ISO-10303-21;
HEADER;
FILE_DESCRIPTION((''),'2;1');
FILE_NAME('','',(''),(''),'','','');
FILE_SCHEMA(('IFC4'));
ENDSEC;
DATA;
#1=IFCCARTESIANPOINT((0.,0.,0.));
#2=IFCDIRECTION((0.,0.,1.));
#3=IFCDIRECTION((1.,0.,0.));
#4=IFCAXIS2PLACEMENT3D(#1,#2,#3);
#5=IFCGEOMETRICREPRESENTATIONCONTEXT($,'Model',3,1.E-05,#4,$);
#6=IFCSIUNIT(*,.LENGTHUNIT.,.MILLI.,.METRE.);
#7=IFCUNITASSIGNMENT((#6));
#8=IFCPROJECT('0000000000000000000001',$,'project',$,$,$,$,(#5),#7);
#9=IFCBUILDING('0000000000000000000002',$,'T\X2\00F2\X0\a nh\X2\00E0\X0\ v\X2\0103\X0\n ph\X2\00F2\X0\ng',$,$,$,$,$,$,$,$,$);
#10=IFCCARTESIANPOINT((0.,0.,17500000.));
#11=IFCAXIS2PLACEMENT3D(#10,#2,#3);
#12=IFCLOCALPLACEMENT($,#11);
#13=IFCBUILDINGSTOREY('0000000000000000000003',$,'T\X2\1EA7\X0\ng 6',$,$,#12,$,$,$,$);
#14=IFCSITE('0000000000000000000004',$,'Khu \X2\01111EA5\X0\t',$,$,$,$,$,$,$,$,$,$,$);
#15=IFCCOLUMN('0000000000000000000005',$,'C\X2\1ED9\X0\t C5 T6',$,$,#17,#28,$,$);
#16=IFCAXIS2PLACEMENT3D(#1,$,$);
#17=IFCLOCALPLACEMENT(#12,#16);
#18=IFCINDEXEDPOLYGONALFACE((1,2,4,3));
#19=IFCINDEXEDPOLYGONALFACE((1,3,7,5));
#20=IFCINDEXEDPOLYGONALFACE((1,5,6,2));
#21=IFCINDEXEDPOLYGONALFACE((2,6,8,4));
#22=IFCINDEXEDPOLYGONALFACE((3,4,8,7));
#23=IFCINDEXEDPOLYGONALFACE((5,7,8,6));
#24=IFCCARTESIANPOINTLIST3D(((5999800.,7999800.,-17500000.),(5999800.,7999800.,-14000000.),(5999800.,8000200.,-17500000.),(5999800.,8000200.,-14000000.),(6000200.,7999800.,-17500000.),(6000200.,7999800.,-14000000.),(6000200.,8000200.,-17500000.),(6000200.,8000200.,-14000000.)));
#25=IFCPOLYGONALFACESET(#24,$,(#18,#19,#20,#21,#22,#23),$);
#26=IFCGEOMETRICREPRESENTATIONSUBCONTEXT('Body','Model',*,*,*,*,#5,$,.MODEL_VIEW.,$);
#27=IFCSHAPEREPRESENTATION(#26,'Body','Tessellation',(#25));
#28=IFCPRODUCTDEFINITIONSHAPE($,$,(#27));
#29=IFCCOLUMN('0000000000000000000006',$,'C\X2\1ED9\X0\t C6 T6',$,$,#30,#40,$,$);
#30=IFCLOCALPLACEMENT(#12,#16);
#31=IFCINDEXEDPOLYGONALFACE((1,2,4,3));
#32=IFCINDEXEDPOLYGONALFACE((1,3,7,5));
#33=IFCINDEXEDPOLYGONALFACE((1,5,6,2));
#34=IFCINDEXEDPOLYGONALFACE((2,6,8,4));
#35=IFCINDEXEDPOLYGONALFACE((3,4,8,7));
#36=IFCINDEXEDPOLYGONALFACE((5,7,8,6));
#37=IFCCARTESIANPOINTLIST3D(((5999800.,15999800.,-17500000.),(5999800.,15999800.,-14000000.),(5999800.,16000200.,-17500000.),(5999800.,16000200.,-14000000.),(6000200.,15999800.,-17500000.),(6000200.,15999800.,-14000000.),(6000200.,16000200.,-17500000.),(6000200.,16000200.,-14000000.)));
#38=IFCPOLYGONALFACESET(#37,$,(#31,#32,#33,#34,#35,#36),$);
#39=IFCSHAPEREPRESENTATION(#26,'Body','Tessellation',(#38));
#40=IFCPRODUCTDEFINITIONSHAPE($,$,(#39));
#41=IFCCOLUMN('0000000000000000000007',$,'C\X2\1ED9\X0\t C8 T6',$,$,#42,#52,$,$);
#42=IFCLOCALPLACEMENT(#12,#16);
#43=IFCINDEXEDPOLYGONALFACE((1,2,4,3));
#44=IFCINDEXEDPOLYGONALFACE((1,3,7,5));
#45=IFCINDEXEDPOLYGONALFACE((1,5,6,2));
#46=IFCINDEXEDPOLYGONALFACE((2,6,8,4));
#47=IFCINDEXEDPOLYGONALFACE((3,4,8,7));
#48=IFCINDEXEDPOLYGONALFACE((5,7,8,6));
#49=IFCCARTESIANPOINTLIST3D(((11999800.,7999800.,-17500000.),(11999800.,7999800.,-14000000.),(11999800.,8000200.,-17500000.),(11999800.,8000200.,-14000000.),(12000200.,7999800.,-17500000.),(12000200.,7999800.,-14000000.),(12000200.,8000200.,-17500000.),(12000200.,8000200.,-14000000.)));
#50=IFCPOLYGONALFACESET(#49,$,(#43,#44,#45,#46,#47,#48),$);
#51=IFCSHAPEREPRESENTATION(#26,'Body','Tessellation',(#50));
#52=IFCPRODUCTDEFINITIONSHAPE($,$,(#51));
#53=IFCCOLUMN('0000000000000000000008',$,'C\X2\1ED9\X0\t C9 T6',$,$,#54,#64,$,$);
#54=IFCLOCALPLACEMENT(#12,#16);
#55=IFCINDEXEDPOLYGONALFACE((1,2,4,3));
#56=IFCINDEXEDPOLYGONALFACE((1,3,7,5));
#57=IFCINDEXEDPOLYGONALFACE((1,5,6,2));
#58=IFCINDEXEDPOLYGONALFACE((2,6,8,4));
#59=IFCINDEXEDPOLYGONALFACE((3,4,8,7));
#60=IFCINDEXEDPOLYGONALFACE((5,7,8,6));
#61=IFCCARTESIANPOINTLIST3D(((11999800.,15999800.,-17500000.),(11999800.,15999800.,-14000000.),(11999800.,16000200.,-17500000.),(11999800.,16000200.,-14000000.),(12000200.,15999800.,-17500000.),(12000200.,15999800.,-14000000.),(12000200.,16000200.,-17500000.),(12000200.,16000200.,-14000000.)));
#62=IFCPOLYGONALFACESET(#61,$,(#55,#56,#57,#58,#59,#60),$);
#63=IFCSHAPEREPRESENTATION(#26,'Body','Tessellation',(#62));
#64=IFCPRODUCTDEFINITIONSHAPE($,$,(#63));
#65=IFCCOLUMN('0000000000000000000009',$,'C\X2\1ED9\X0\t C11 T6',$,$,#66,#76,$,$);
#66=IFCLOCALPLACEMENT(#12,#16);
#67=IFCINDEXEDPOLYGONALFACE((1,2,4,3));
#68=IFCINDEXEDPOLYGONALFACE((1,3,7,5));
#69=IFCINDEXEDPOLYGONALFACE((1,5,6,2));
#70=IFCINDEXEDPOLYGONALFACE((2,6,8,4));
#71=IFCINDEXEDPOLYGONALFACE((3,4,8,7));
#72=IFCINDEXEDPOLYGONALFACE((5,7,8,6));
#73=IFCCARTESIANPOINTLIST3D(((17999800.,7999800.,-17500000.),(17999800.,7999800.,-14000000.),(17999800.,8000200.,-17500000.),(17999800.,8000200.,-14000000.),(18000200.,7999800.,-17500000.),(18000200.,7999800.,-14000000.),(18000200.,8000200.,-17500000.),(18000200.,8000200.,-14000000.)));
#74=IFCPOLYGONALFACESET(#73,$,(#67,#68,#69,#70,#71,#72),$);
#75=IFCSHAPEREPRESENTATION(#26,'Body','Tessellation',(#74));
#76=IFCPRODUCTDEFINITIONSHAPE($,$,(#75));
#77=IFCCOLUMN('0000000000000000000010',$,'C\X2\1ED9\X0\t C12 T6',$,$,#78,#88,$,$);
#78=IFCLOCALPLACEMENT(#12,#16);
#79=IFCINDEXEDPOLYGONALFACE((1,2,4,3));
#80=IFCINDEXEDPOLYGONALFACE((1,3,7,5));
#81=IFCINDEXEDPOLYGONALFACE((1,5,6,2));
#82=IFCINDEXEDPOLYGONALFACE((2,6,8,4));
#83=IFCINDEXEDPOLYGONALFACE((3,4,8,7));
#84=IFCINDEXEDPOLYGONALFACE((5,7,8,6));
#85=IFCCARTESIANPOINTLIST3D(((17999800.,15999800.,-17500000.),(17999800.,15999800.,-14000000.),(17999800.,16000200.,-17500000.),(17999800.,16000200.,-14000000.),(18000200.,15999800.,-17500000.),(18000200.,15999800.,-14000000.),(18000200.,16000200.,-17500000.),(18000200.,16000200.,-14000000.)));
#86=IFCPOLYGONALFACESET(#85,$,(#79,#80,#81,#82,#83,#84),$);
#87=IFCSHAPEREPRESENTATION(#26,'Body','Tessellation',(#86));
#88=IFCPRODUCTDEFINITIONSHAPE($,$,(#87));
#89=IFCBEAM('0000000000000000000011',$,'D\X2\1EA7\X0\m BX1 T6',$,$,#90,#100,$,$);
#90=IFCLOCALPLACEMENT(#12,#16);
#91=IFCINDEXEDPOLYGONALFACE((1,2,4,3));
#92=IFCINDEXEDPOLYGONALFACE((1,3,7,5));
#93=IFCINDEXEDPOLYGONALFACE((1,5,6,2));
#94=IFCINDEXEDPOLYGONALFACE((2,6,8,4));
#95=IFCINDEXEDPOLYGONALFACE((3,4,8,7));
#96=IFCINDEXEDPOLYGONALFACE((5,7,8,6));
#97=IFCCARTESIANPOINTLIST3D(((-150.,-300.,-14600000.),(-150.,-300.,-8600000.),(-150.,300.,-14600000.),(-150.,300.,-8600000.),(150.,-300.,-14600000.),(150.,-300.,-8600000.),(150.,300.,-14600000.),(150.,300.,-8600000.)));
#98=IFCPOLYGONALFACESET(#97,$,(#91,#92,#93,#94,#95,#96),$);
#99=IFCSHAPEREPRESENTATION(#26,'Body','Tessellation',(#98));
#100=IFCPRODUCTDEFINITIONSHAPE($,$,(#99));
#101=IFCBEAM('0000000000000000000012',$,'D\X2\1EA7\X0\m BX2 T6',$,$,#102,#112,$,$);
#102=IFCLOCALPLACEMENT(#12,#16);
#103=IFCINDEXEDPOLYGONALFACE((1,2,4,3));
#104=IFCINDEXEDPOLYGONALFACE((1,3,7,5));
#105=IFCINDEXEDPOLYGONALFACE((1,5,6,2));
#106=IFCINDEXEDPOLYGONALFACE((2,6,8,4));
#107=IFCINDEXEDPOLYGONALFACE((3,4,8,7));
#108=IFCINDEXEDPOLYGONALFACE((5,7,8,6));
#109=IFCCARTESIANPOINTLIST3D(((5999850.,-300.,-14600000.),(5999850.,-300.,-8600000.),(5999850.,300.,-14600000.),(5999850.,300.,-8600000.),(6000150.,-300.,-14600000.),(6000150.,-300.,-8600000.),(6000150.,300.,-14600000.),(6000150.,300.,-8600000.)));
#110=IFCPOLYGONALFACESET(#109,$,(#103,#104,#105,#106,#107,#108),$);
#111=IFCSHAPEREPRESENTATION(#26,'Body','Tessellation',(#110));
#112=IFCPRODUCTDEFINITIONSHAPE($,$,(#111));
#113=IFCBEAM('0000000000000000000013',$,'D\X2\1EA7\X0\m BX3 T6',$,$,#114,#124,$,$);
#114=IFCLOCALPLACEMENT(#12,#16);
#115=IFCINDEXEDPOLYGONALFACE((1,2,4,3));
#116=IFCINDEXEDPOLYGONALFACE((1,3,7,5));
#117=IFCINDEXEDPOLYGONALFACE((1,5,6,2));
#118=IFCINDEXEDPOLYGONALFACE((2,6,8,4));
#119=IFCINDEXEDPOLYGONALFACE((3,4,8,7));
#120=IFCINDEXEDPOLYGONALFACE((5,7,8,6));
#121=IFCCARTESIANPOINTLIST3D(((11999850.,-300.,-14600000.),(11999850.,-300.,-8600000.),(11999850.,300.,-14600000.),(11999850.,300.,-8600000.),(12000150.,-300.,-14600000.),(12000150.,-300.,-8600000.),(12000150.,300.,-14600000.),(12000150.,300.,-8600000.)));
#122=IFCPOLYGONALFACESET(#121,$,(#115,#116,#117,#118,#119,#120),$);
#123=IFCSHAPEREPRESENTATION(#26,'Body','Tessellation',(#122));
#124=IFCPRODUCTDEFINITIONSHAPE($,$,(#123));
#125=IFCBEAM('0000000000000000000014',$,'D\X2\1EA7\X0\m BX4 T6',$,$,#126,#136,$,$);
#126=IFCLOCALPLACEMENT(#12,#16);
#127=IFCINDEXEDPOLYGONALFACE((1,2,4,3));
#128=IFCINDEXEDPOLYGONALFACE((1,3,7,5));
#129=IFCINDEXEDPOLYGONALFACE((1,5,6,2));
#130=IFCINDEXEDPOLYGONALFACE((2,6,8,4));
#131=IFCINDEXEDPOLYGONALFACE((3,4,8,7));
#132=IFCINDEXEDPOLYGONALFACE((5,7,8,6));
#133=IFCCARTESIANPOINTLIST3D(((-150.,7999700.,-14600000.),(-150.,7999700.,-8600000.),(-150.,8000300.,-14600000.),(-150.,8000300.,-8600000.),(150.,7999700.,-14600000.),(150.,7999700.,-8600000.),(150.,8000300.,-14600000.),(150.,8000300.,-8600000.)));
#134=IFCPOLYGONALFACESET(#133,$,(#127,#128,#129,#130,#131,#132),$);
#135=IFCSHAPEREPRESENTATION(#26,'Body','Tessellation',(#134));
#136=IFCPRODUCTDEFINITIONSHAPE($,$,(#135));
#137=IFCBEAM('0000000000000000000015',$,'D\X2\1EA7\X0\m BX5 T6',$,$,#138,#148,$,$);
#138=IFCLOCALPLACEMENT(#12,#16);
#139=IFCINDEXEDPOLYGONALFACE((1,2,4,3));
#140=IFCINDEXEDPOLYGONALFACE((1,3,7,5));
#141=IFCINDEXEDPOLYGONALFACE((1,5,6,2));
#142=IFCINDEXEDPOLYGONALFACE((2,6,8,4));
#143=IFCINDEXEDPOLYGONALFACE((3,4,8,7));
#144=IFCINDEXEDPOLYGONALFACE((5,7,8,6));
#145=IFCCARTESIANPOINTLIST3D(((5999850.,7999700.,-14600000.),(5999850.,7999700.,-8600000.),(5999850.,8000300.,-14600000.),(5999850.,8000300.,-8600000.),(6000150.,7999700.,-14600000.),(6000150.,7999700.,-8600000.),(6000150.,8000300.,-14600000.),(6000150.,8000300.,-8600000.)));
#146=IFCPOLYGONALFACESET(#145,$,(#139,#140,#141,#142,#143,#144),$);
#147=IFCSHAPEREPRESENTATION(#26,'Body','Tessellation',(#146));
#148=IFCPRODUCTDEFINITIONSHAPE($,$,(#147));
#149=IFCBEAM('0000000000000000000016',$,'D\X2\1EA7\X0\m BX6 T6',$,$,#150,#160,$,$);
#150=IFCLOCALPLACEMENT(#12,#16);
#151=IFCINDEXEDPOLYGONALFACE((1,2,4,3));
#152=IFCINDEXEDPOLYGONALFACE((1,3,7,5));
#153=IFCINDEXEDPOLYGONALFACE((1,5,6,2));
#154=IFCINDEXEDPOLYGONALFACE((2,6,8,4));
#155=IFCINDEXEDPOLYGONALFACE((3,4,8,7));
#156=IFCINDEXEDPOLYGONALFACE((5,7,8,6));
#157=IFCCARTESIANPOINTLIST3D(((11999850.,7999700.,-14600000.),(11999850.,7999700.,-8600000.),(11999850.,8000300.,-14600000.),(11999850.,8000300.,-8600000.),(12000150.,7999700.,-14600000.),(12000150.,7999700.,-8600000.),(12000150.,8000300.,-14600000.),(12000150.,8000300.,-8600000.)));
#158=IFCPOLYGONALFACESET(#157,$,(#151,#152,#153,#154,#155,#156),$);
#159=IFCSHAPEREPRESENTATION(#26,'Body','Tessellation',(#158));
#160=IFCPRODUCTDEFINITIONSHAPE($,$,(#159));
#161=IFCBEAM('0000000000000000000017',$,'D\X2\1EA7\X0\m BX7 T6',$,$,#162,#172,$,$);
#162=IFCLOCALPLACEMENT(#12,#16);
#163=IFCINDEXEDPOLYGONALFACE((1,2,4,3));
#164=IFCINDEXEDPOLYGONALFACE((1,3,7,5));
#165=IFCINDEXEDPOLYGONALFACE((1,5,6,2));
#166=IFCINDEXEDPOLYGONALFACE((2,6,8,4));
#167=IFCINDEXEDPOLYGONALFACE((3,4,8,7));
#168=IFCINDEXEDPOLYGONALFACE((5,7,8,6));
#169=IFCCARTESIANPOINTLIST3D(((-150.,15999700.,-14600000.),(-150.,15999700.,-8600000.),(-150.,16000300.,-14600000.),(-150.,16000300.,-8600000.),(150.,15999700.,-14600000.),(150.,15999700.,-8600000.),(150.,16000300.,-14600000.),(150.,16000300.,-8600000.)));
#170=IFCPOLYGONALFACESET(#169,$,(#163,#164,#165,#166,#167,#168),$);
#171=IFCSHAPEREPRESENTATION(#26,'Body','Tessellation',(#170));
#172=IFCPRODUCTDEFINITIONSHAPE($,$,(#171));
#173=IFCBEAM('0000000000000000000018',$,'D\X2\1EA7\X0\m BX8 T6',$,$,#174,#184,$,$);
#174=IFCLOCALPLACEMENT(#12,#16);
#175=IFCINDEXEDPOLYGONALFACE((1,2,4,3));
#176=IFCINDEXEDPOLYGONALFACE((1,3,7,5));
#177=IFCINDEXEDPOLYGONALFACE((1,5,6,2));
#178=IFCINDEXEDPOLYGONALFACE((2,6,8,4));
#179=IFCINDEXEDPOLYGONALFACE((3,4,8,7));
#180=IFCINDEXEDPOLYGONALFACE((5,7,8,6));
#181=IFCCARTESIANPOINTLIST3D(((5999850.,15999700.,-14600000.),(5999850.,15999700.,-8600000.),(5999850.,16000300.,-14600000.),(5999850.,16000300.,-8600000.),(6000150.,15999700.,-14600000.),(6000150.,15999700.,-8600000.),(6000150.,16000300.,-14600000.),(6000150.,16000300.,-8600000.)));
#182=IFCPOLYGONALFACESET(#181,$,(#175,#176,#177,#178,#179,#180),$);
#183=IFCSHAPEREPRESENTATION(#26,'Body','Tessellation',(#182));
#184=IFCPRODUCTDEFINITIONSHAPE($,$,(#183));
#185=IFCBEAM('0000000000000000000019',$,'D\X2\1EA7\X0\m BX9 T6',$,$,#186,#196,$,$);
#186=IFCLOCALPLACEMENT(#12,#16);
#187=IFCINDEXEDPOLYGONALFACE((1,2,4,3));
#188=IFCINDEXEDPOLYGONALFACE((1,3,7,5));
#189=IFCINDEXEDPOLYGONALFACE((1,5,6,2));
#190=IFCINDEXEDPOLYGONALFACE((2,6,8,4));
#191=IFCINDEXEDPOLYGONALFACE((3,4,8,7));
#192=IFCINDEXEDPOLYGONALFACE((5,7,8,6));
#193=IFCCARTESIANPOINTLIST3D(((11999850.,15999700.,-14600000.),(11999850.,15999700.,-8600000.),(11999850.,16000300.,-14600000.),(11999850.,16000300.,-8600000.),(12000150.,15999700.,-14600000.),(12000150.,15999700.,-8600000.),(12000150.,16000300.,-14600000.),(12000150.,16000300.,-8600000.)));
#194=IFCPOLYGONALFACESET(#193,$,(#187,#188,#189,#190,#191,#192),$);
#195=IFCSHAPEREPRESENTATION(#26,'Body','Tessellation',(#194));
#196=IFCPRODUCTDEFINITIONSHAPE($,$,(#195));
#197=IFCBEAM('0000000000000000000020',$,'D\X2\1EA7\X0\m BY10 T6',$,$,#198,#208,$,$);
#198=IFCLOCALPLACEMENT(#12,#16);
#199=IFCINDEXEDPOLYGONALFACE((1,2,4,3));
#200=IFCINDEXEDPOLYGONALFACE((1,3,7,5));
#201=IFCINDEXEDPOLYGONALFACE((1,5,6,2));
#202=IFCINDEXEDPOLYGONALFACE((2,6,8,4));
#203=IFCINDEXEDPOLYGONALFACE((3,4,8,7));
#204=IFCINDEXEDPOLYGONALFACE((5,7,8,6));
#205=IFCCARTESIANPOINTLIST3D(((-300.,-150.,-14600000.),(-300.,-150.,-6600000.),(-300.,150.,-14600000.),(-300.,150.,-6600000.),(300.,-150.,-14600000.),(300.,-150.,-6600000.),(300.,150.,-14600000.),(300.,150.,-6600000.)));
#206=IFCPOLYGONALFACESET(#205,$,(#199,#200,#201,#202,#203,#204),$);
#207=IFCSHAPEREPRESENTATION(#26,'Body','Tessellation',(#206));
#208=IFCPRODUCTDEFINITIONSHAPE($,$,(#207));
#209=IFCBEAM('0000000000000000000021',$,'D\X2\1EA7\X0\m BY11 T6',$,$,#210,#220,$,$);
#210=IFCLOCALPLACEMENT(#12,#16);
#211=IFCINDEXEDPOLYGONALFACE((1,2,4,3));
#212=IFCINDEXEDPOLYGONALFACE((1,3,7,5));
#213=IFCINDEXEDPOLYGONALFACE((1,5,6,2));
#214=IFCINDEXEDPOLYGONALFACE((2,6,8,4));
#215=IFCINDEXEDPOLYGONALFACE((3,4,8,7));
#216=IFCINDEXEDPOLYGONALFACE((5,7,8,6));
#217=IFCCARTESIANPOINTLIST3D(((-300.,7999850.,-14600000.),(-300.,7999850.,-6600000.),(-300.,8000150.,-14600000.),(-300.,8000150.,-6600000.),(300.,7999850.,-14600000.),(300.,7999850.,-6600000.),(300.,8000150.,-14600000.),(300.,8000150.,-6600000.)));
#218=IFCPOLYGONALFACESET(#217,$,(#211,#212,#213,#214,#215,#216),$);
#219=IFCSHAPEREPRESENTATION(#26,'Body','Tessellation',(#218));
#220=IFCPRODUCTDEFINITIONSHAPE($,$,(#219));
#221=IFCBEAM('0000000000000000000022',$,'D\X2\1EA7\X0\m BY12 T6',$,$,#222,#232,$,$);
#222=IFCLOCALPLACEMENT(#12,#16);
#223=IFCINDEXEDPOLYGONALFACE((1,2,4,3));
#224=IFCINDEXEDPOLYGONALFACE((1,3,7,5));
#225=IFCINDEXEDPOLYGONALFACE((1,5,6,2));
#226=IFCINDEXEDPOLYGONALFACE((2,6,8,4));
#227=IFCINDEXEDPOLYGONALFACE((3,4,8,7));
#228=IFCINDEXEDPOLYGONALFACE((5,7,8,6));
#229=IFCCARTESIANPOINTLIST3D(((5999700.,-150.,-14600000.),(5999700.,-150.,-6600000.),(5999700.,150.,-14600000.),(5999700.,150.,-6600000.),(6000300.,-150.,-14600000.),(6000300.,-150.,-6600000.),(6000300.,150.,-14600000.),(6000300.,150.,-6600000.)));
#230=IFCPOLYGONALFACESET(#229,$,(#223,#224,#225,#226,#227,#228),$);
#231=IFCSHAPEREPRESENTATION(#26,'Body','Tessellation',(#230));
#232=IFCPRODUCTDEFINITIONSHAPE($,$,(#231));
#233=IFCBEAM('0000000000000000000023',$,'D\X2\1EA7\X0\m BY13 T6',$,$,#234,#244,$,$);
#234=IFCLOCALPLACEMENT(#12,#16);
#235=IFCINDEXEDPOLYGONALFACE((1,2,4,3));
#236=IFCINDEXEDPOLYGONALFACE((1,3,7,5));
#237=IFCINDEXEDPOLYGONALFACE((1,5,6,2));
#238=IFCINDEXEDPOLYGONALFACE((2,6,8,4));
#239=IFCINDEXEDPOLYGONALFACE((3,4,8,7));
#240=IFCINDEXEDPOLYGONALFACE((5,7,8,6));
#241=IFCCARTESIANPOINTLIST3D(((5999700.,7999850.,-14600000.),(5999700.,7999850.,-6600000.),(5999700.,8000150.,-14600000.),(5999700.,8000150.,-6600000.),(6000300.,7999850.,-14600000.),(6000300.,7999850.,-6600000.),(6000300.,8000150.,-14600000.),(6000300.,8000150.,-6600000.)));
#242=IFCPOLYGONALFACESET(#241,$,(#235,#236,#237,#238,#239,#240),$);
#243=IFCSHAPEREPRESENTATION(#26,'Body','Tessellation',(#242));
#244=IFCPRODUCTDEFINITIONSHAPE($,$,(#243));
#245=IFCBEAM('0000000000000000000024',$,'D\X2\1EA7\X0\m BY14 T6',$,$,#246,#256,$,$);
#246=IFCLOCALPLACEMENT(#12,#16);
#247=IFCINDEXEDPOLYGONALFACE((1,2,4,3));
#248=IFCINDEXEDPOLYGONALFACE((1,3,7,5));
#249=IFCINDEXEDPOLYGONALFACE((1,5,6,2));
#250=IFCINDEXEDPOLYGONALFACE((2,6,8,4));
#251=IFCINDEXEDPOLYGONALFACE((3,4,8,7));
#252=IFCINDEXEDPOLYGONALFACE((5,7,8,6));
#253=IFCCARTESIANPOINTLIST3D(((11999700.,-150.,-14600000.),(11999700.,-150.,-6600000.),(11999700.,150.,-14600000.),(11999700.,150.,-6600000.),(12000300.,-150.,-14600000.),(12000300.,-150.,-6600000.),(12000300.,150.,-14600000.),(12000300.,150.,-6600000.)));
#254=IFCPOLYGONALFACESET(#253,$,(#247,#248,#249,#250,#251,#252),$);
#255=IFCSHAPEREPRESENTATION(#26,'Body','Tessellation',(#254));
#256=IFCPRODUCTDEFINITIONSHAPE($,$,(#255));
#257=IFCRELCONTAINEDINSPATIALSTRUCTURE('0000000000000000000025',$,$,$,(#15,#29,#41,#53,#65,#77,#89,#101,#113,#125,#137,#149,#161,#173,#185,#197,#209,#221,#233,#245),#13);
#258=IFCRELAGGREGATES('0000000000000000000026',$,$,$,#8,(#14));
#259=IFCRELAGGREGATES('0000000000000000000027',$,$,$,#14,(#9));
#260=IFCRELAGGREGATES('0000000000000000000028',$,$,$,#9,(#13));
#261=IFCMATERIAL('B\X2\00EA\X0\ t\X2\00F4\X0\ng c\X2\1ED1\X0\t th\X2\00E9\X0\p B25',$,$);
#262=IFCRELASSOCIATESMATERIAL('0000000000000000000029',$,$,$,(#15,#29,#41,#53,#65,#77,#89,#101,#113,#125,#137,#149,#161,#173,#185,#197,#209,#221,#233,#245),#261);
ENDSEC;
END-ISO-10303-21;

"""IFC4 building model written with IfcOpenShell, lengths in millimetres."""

from ifc_helpers import new_model, entity, si_unit, frame, origin_with_axes, place, context, subcontext, project, spatial, extrude, material, element, save


model = new_model("IFC4")

# Units and contexts
model_context = context("Model", 3, precision=1e-05, world=origin_with_axes())
body_context = subcontext(model_context, "Body", "Model", "MODEL_VIEW")
ifc_project = project(units=[si_unit("LENGTHUNIT", "METRE", prefix="MILLI")], contexts=[model_context])

# Site, building, storey
site = spatial("IfcSite", under=ifc_project, Name="Khu đất")
building = spatial("IfcBuilding", under=site, Name="Tòa nhà văn phòng")
storey_placement = place(None, frame((0.0, 0.0, 17500000.0), z_axis=(0.0, 0.0, 1.0), x_axis=(1.0, 0.0, 0.0)))
storey = spatial("IfcBuildingStorey", under=building, at=storey_placement, Name="Tầng 6")

# Columns
ifc_material_1 = material(Name="Bê tông cốt thép B25")
for number, where, z_axis, x_axis, name in (
    (1, (6000000.0, 8000000.0, -17500000.0), (0.0, 0.0, 1.0), (1.0, 0.0, 0.0), "Cột C5 T6"),
    (2, (6000000.0, 16000000.0, -17500000.0), (0.0, 0.0, 1.0), (1.0, 0.0, 0.0), "Cột C6 T6"),
    (3, (12000000.0, 8000000.0, -17500000.0), (0.0, 0.0, 1.0), (1.0, 0.0, 0.0), "Cột C8 T6"),
    (4, (12000000.0, 16000000.0, -17500000.0), (0.0, 0.0, 1.0), (1.0, 0.0, 0.0), "Cột C9 T6"),
    (5, (18000000.0, 8000000.0, -17500000.0), (0.0, 0.0, 1.0), (1.0, 0.0, 0.0), "Cột C11 T6"),
    (6, (18000000.0, 16000000.0, -17500000.0), (0.0, 0.0, 1.0), (1.0, 0.0, 0.0), "Cột C12 T6"),
):
    element("IfcColumn", number, at=place(storey_placement, frame(where, z_axis=z_axis, x_axis=x_axis)), inside=storey, material=ifc_material_1, Name=name, context=body_context, shape_type="SweptSolid", body=[
        extrude(entity("IfcRectangleProfileDef", None, None, None, 400.0, 400.0), origin_with_axes(), (0.0, 0.0, 1.0), 3500000.0),
    ])

# Beams
for number, where, z_axis, x_axis, name in (
    (7, (0.0, 0.0, -14600000.0), (0.0, 0.0, 1.0), (1.0, 0.0, 0.0), "Dầm BX1 T6"),
    (8, (6000000.0, 0.0, -14600000.0), (0.0, 0.0, 1.0), (1.0, 0.0, 0.0), "Dầm BX2 T6"),
    (9, (12000000.0, 0.0, -14600000.0), (0.0, 0.0, 1.0), (1.0, 0.0, 0.0), "Dầm BX3 T6"),
    (10, (0.0, 8000000.0, -14600000.0), (0.0, 0.0, 1.0), (1.0, 0.0, 0.0), "Dầm BX4 T6"),
    (11, (6000000.0, 8000000.0, -14600000.0), (0.0, 0.0, 1.0), (1.0, 0.0, 0.0), "Dầm BX5 T6"),
    (12, (12000000.0, 8000000.0, -14600000.0), (0.0, 0.0, 1.0), (1.0, 0.0, 0.0), "Dầm BX6 T6"),
    (13, (0.0, 16000000.0, -14600000.0), (0.0, 0.0, 1.0), (1.0, 0.0, 0.0), "Dầm BX7 T6"),
    (14, (6000000.0, 16000000.0, -14600000.0), (0.0, 0.0, 1.0), (1.0, 0.0, 0.0), "Dầm BX8 T6"),
    (15, (12000000.0, 16000000.0, -14600000.0), (0.0, 0.0, 1.0), (1.0, 0.0, 0.0), "Dầm BX9 T6"),
):
    element("IfcBeam", number, at=place(storey_placement, frame(where, z_axis=z_axis, x_axis=x_axis)), inside=storey, material=ifc_material_1, Name=name, context=body_context, shape_type="SweptSolid", body=[
        extrude(entity("IfcRectangleProfileDef", None, None, None, 300.0, 600.0), origin_with_axes(), (0.0, 0.0, 1.0), 6000000.0),
    ])
for number, where, z_axis, x_axis, name in (
    (16, (0.0, 0.0, -14600000.0), (0.0, 0.0, 1.0), (0.0, 1.0, 0.0), "Dầm BY10 T6"),
    (17, (0.0, 8000000.0, -14600000.0), (0.0, 0.0, 1.0), (0.0, 1.0, 0.0), "Dầm BY11 T6"),
    (18, (6000000.0, 0.0, -14600000.0), (0.0, 0.0, 1.0), (0.0, 1.0, 0.0), "Dầm BY12 T6"),
    (19, (6000000.0, 8000000.0, -14600000.0), (0.0, 0.0, 1.0), (0.0, 1.0, 0.0), "Dầm BY13 T6"),
    (20, (12000000.0, 0.0, -14600000.0), (0.0, 0.0, 1.0), (0.0, 1.0, 0.0), "Dầm BY14 T6"),
):
    element("IfcBeam", number, at=place(storey_placement, frame(where, z_axis=z_axis, x_axis=x_axis)), inside=storey, material=ifc_material_1, Name=name, context=body_context, shape_type="SweptSolid", body=[
        extrude(entity("IfcRectangleProfileDef", None, None, None, 300.0, 600.0), origin_with_axes(), (0.0, 0.0, 1.0), 8000000.0),
    ])

save(model, "model.ifc")
